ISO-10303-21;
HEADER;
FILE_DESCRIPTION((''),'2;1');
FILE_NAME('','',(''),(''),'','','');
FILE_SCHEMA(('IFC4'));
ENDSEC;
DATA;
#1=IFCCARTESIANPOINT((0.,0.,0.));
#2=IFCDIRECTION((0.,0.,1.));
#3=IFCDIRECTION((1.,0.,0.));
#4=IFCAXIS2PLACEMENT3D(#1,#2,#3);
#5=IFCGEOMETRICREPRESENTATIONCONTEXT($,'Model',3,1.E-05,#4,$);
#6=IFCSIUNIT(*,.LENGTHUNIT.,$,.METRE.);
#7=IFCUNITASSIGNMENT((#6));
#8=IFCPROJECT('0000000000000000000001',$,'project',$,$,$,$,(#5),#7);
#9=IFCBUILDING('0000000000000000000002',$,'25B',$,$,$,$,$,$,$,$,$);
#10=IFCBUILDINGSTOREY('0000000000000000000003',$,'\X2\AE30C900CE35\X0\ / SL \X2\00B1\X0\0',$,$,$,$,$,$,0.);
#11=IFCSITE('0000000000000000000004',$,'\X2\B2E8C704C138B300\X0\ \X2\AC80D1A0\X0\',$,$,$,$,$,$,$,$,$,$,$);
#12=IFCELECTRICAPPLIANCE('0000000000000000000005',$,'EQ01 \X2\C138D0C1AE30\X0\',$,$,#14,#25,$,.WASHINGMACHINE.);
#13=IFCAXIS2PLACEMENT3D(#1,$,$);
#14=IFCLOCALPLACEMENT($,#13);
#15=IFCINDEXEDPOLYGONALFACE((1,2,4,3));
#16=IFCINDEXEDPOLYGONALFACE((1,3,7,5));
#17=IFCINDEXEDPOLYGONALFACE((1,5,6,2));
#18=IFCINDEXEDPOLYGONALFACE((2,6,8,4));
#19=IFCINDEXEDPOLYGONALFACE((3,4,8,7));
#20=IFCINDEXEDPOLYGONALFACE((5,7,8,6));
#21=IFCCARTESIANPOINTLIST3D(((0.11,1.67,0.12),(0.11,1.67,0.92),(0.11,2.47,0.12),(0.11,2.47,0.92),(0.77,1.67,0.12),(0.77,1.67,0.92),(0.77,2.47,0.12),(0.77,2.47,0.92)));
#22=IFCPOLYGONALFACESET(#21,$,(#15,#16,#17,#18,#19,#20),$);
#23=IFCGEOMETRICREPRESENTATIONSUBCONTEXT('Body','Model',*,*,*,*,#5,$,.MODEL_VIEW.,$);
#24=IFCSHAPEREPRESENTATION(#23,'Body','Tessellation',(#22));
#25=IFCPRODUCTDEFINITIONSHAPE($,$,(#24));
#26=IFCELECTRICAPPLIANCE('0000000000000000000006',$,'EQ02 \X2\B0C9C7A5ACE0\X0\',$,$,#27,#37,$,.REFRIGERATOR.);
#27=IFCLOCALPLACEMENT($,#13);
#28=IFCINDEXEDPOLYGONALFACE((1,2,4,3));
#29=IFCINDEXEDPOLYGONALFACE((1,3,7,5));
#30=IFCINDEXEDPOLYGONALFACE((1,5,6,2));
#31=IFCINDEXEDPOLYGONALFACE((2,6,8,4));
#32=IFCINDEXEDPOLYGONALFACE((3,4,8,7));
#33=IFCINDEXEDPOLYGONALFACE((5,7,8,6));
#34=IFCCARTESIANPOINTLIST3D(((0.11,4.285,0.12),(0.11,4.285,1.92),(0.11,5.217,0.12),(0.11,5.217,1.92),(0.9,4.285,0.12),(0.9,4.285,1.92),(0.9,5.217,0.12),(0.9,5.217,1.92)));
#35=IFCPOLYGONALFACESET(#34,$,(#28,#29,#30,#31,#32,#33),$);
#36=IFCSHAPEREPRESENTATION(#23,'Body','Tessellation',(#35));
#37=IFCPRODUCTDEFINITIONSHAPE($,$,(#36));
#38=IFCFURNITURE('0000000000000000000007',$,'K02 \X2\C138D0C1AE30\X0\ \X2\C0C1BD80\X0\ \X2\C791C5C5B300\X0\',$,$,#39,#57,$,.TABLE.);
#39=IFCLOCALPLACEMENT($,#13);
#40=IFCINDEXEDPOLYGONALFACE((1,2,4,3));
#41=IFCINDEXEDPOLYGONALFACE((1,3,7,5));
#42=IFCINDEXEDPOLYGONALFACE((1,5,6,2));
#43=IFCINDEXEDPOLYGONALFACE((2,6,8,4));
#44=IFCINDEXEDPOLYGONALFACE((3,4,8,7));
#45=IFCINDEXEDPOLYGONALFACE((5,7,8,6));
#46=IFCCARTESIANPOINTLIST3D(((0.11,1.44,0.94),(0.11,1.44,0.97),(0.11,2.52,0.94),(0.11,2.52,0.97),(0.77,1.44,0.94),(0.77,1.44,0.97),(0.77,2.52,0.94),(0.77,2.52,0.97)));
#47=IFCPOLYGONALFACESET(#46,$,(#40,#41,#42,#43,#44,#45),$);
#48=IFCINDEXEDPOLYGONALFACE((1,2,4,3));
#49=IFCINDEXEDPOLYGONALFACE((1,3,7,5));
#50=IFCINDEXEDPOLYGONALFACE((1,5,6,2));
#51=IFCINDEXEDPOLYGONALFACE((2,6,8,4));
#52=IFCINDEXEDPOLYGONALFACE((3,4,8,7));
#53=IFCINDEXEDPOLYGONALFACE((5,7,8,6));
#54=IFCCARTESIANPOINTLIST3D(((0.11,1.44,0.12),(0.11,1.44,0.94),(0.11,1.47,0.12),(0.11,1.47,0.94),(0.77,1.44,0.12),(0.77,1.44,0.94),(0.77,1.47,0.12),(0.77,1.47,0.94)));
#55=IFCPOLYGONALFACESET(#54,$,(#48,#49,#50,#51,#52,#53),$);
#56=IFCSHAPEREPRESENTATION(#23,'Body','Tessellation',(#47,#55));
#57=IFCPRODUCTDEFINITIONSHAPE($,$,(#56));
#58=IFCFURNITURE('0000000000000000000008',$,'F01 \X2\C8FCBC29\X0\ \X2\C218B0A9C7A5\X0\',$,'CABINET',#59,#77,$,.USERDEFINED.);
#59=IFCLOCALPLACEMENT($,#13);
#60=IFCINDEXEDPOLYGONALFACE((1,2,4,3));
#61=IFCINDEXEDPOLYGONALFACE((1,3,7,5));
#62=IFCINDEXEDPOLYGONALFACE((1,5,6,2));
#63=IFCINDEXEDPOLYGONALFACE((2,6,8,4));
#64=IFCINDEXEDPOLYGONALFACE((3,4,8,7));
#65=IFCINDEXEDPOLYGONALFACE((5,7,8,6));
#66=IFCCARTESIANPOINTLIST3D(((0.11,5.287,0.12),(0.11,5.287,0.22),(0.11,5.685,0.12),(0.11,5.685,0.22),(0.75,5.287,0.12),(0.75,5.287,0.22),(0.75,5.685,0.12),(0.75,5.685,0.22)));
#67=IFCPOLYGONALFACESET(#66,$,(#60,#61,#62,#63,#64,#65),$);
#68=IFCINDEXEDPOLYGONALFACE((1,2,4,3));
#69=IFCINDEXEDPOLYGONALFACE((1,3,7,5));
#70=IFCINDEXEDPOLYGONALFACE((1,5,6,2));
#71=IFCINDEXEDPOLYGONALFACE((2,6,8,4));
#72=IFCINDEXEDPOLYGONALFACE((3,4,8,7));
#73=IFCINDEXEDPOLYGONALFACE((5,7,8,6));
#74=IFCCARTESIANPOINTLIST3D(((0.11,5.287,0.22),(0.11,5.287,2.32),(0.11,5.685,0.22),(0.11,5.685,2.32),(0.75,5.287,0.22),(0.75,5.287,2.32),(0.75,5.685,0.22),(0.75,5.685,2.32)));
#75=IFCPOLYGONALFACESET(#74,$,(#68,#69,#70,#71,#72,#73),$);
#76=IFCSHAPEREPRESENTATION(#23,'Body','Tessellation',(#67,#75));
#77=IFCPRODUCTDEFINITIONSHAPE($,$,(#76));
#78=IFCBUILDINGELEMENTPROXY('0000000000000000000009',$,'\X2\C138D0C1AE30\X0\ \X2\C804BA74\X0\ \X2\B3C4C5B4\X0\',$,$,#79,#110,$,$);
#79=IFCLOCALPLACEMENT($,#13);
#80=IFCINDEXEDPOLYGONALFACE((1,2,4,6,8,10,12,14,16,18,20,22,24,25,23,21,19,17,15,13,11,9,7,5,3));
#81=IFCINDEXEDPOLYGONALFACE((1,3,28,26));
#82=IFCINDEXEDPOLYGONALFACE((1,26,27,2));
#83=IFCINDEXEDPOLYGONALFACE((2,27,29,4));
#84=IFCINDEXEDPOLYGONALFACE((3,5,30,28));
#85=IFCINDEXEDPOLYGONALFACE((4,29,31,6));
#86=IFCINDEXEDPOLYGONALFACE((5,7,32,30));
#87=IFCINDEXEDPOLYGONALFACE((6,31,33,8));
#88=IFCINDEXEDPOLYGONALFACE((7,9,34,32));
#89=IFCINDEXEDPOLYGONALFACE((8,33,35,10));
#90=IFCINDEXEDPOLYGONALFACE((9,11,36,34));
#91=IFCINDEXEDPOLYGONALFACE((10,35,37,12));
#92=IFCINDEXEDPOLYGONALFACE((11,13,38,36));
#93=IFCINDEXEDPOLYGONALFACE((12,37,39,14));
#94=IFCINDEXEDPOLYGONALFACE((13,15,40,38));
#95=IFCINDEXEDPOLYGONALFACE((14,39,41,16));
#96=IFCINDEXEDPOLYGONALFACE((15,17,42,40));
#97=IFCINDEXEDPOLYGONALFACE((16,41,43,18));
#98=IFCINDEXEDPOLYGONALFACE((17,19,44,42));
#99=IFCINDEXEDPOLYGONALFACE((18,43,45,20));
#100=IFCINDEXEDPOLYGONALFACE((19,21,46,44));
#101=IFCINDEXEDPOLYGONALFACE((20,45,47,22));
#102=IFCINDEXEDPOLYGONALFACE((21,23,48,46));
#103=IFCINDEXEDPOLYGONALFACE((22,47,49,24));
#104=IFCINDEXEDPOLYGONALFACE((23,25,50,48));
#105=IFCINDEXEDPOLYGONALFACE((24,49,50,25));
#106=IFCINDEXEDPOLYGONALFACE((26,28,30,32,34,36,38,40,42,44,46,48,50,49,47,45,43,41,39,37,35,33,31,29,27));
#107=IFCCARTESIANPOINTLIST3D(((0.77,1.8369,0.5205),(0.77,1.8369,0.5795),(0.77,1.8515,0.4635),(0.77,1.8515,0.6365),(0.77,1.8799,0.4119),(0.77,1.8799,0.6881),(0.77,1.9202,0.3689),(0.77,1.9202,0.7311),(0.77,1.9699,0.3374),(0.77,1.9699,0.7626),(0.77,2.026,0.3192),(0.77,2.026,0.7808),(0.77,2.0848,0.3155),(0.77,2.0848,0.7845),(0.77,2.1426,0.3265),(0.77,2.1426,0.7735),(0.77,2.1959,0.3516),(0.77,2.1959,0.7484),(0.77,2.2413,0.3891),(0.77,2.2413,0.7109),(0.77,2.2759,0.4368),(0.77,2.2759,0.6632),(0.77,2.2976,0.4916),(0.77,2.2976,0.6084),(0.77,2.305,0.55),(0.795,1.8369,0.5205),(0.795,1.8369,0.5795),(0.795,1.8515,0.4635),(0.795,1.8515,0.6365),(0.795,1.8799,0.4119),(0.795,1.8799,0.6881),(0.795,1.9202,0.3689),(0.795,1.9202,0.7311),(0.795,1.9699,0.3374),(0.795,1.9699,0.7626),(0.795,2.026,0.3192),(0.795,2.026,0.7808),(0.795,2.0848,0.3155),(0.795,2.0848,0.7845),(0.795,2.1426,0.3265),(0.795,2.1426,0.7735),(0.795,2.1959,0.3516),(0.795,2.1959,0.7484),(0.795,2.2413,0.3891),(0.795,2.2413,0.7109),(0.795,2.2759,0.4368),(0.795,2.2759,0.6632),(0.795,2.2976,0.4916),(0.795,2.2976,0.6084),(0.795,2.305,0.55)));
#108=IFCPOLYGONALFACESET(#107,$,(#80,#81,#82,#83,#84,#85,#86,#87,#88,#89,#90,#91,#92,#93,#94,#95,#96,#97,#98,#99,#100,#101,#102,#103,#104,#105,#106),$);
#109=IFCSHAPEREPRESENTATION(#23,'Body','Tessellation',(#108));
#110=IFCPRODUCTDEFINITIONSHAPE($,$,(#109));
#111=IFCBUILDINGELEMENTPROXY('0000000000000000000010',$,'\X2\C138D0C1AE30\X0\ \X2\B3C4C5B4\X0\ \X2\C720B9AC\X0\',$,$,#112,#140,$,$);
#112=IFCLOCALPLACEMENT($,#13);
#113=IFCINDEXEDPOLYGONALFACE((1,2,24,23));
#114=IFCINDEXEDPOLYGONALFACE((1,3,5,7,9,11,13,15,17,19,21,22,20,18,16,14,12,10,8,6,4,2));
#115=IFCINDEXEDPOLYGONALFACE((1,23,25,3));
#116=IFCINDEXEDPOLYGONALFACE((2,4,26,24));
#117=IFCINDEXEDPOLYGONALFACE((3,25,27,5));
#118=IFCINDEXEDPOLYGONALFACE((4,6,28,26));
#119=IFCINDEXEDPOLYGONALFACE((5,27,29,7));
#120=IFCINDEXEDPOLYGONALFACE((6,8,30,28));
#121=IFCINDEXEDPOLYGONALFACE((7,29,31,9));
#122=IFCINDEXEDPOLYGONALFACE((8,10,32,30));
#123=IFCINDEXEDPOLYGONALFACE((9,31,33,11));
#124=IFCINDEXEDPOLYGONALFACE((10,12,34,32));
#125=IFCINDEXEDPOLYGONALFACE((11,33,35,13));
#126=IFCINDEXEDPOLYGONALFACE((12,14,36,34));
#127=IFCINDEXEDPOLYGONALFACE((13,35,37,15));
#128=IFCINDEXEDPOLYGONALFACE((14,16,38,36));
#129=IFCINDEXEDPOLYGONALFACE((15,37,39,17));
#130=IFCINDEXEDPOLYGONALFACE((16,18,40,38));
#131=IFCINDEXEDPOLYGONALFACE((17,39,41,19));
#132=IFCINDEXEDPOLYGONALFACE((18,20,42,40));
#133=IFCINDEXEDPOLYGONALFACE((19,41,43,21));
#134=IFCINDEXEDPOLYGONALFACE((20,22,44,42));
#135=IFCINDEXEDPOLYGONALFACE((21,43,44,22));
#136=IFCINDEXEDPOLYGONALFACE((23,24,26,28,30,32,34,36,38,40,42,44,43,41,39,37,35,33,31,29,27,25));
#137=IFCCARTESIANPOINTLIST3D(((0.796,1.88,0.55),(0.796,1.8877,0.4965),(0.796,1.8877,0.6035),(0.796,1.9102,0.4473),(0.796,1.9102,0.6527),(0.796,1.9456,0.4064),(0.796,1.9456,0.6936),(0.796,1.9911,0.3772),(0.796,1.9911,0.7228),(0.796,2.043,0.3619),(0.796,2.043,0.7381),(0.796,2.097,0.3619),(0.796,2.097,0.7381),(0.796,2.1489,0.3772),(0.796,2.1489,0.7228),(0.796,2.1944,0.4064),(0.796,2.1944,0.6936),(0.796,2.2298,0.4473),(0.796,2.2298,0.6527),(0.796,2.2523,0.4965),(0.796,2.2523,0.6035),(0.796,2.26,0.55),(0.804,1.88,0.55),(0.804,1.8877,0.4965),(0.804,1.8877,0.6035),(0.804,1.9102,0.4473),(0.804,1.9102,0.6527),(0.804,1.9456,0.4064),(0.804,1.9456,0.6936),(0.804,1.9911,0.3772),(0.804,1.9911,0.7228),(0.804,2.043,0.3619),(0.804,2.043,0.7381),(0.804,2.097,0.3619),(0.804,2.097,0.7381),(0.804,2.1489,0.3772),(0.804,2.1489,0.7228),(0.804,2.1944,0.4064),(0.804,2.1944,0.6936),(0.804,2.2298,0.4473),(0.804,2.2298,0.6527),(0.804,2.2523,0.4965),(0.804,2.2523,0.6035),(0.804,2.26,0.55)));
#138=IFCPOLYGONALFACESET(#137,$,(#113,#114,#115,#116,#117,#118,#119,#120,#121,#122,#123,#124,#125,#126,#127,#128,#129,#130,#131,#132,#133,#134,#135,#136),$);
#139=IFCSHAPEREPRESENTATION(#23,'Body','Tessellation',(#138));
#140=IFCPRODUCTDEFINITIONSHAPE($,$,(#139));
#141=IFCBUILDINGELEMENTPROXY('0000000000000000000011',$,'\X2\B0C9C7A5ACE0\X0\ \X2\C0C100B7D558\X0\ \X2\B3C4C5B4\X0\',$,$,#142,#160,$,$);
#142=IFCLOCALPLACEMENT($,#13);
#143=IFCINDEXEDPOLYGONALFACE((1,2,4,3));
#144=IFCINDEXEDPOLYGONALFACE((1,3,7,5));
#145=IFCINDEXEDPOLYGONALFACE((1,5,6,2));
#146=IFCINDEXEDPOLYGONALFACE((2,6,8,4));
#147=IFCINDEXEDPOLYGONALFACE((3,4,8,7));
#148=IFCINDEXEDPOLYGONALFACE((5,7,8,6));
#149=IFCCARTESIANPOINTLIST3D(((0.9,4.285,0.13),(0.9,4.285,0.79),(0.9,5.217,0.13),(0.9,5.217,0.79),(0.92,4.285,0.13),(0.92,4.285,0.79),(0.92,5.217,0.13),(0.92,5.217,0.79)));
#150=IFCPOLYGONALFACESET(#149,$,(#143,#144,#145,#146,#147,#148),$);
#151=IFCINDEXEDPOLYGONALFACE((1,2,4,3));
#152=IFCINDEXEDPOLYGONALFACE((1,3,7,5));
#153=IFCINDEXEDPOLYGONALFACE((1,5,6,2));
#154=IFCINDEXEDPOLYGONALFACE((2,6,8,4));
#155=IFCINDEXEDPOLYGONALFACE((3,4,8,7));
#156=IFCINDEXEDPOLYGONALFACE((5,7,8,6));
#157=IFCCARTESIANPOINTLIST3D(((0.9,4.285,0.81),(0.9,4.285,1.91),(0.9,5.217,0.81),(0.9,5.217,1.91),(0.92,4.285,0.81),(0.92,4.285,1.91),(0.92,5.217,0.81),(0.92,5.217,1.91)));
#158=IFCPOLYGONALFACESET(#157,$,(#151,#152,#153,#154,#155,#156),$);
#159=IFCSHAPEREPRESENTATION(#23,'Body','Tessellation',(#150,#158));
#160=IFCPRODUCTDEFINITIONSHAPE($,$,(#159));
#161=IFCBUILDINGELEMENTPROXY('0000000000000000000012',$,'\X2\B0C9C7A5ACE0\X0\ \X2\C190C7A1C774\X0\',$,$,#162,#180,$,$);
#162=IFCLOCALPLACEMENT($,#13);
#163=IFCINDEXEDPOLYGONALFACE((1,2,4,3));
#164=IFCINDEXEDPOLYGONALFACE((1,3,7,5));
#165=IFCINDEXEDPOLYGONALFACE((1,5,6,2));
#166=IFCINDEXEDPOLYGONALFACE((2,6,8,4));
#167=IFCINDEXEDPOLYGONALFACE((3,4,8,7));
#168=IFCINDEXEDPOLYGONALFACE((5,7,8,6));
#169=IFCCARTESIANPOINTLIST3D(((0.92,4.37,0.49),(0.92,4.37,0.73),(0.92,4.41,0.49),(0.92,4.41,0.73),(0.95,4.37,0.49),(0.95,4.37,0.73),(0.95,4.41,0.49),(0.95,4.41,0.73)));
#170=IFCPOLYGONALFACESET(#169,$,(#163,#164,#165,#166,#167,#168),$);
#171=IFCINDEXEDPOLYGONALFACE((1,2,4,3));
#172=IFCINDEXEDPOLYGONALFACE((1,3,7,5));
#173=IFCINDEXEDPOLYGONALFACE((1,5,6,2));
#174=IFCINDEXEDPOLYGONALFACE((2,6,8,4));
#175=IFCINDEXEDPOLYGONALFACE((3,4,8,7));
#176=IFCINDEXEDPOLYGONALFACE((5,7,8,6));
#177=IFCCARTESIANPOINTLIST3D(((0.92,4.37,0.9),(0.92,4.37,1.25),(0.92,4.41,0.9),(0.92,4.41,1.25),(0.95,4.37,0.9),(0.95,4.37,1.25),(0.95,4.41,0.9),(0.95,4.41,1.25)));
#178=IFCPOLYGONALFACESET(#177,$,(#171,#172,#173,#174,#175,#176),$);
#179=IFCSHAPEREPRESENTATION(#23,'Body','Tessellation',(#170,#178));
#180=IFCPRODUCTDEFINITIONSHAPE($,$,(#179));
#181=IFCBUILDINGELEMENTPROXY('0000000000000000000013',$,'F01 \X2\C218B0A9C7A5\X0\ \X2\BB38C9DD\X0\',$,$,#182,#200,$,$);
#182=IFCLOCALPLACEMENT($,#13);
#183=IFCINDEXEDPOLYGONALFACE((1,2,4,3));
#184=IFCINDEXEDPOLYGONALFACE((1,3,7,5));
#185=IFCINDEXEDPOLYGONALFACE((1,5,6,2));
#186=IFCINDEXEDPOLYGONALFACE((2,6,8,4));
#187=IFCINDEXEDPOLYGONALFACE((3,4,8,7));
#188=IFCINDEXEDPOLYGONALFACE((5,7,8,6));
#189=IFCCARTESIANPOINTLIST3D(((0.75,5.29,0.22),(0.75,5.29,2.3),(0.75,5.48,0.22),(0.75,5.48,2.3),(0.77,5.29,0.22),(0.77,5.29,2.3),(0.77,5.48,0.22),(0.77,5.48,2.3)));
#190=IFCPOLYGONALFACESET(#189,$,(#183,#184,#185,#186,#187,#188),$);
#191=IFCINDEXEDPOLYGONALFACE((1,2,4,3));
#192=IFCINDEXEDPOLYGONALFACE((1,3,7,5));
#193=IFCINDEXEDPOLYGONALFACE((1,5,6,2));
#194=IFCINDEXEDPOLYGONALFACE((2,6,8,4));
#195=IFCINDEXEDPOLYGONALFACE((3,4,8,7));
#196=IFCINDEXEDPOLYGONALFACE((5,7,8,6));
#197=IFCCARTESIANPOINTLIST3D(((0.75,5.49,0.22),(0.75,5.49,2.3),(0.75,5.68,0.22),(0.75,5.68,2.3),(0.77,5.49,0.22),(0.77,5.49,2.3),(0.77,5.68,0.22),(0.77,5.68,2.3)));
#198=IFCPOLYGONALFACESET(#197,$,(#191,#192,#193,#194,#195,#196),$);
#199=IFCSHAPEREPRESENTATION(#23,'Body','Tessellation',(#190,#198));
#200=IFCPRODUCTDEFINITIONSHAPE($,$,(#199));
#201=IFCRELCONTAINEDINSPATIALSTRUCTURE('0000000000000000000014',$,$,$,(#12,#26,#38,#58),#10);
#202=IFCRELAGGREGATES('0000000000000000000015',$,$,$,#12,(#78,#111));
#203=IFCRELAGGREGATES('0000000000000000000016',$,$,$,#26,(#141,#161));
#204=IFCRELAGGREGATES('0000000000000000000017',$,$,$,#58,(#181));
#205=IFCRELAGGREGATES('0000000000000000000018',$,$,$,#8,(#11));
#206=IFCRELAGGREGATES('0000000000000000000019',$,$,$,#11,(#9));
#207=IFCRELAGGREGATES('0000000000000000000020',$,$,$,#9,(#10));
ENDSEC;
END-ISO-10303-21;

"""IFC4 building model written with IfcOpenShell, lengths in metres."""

from ifc_helpers import new_model, si_unit, frame, origin_with_axes, place, context, subcontext, project, spatial, polyline, circle, outline, extrude, element, aggregate, save


model = new_model("IFC4")

# Units and contexts
model_context = context("Model", 3, precision=1e-05, world=origin_with_axes())
body_context = subcontext(model_context, "Body", "Model", "MODEL_VIEW")
ifc_project = project(units=[si_unit("LENGTHUNIT", "METRE")], contexts=[model_context])

# Site, building, storey
site = spatial("IfcSite", under=ifc_project, Name="단위세대 검토")
building = spatial("IfcBuilding", under=site, Name="25B")
storey = spatial("IfcBuildingStorey", under=building, Name="기준층 / SL ±0", Elevation=0.0)

# Electric appliances
electric_appliance_1_placement = place(None, origin_with_axes())
electric_appliance_1 = element("IfcElectricAppliance", 1, at=electric_appliance_1_placement, inside=storey, Name="EQ01 세탁기", PredefinedType="WASHINGMACHINE", context=body_context, shape_type="SweptSolid", body=[
    extrude(outline(polyline([(0.77, 1.67), (0.77, 2.47), (0.11, 2.47), (0.11, 1.67), (0.77, 1.67)])), frame((0.0, 0.0, 0.12)), (0.0, 0.0, 1.0), 0.8),
])
electric_appliance_2_placement = place(None, origin_with_axes())
electric_appliance_2 = element("IfcElectricAppliance", 2, at=electric_appliance_2_placement, inside=storey, Name="EQ02 냉장고", PredefinedType="REFRIGERATOR", context=body_context, shape_type="SweptSolid", body=[
    extrude(outline(polyline([(0.9, 4.285), (0.9, 5.217), (0.11, 5.217), (0.11, 4.285), (0.9, 4.285)])), frame((0.0, 0.0, 0.12)), (0.0, 0.0, 1.0), 1.8),
])

# Furniture
furniture_1_placement = place(None, origin_with_axes())
element("IfcFurniture", 3, at=furniture_1_placement, inside=storey, Name="K02 세탁기 상부 작업대", PredefinedType="TABLE", context=body_context, shape_type="SweptSolid", body=[
    extrude(outline(polyline([(0.11, 1.44), (0.77, 1.44), (0.77, 2.52), (0.11, 2.52), (0.11, 1.44)])), frame((0.0, 0.0, 0.94)), (0.0, 0.0, 1.0), 0.03),
    extrude(outline(polyline([(0.77, 1.44), (0.77, 1.47), (0.11, 1.47), (0.11, 1.44), (0.77, 1.44)])), frame((0.0, 0.0, 0.12)), (0.0, 0.0, 1.0), 0.82),
])
furniture_2_placement = place(None, origin_with_axes())
furniture_2 = element("IfcFurniture", 4, at=furniture_2_placement, inside=storey, Name="F01 주방 수납장", ObjectType="CABINET", PredefinedType="USERDEFINED", context=body_context, shape_type="SweptSolid", body=[
    extrude(outline(polyline([(0.75, 5.287), (0.75, 5.685), (0.11, 5.685), (0.11, 5.287), (0.75, 5.287)])), frame((0.0, 0.0, 0.12)), (0.0, 0.0, 1.0), 0.1),
    extrude(outline(polyline([(0.75, 5.287), (0.75, 5.685), (0.11, 5.685), (0.11, 5.287), (0.75, 5.287)])), frame((0.0, 0.0, 0.22)), (0.0, 0.0, 1.0), 2.1),
])

# Building element proxies
proxy_1_placement = place(electric_appliance_1_placement, origin_with_axes())
proxy_1 = element("IfcBuildingElementProxy", 5, at=proxy_1_placement, Name="세탁기 전면 도어", context=body_context, shape_type="SweptSolid", body=[
    extrude(circle(Radius=0.235), frame((0.77, 2.07, 0.55), z_axis=(1.0, 0.0, 0.0), x_axis=(0.0, 1.0, 0.0)), (0.0, 0.0, 1.0), 0.025),
])
proxy_2_placement = place(electric_appliance_1_placement, origin_with_axes())
proxy_2 = element("IfcBuildingElementProxy", 6, at=proxy_2_placement, Name="세탁기 도어 유리", context=body_context, shape_type="SweptSolid", body=[
    extrude(circle(Radius=0.19), frame((0.796, 2.07, 0.55), z_axis=(1.0, 0.0, 0.0), x_axis=(0.0, 1.0, 0.0)), (0.0, 0.0, 1.0), 0.008),
])
aggregate(electric_appliance_1, [proxy_1, proxy_2])
proxy_3_placement = place(electric_appliance_2_placement, origin_with_axes())
proxy_3 = element("IfcBuildingElementProxy", 7, at=proxy_3_placement, Name="냉장고 상·하 도어", context=body_context, shape_type="SweptSolid", body=[
    extrude(outline(polyline([(0.92, 4.285), (0.92, 5.217), (0.9, 5.217), (0.9, 4.285), (0.92, 4.285)])), frame((0.0, 0.0, 0.13)), (0.0, 0.0, 1.0), 0.66),
    extrude(outline(polyline([(0.92, 4.285), (0.92, 5.217), (0.9, 5.217), (0.9, 4.285), (0.92, 4.285)])), frame((0.0, 0.0, 0.81)), (0.0, 0.0, 1.0), 1.1),
])
proxy_4_placement = place(electric_appliance_2_placement, origin_with_axes())
proxy_4 = element("IfcBuildingElementProxy", 8, at=proxy_4_placement, Name="냉장고 손잡이", context=body_context, shape_type="SweptSolid", body=[
    extrude(outline(polyline([(0.95, 4.37), (0.95, 4.41), (0.92, 4.41), (0.92, 4.37), (0.95, 4.37)])), frame((0.0, 0.0, 0.49)), (0.0, 0.0, 1.0), 0.24),
    extrude(outline(polyline([(0.95, 4.37), (0.95, 4.41), (0.92, 4.41), (0.92, 4.37), (0.95, 4.37)])), frame((0.0, 0.0, 0.9)), (0.0, 0.0, 1.0), 0.35),
])
aggregate(electric_appliance_2, [proxy_3, proxy_4])
proxy_5_placement = place(furniture_2_placement, origin_with_axes())
proxy_5 = element("IfcBuildingElementProxy", 9, at=proxy_5_placement, Name="F01 수납장 문짝", context=body_context, shape_type="SweptSolid", body=[
    extrude(outline(polyline([(0.77, 5.29), (0.77, 5.48), (0.75, 5.48), (0.75, 5.29), (0.77, 5.29)])), frame((0.0, 0.0, 0.22)), (0.0, 0.0, 1.0), 2.08),
    extrude(outline(polyline([(0.77, 5.49), (0.77, 5.68), (0.75, 5.68), (0.75, 5.49), (0.77, 5.49)])), frame((0.0, 0.0, 0.22)), (0.0, 0.0, 1.0), 2.08),
])
aggregate(furniture_2, [proxy_5])

save(model, "model.ifc")
